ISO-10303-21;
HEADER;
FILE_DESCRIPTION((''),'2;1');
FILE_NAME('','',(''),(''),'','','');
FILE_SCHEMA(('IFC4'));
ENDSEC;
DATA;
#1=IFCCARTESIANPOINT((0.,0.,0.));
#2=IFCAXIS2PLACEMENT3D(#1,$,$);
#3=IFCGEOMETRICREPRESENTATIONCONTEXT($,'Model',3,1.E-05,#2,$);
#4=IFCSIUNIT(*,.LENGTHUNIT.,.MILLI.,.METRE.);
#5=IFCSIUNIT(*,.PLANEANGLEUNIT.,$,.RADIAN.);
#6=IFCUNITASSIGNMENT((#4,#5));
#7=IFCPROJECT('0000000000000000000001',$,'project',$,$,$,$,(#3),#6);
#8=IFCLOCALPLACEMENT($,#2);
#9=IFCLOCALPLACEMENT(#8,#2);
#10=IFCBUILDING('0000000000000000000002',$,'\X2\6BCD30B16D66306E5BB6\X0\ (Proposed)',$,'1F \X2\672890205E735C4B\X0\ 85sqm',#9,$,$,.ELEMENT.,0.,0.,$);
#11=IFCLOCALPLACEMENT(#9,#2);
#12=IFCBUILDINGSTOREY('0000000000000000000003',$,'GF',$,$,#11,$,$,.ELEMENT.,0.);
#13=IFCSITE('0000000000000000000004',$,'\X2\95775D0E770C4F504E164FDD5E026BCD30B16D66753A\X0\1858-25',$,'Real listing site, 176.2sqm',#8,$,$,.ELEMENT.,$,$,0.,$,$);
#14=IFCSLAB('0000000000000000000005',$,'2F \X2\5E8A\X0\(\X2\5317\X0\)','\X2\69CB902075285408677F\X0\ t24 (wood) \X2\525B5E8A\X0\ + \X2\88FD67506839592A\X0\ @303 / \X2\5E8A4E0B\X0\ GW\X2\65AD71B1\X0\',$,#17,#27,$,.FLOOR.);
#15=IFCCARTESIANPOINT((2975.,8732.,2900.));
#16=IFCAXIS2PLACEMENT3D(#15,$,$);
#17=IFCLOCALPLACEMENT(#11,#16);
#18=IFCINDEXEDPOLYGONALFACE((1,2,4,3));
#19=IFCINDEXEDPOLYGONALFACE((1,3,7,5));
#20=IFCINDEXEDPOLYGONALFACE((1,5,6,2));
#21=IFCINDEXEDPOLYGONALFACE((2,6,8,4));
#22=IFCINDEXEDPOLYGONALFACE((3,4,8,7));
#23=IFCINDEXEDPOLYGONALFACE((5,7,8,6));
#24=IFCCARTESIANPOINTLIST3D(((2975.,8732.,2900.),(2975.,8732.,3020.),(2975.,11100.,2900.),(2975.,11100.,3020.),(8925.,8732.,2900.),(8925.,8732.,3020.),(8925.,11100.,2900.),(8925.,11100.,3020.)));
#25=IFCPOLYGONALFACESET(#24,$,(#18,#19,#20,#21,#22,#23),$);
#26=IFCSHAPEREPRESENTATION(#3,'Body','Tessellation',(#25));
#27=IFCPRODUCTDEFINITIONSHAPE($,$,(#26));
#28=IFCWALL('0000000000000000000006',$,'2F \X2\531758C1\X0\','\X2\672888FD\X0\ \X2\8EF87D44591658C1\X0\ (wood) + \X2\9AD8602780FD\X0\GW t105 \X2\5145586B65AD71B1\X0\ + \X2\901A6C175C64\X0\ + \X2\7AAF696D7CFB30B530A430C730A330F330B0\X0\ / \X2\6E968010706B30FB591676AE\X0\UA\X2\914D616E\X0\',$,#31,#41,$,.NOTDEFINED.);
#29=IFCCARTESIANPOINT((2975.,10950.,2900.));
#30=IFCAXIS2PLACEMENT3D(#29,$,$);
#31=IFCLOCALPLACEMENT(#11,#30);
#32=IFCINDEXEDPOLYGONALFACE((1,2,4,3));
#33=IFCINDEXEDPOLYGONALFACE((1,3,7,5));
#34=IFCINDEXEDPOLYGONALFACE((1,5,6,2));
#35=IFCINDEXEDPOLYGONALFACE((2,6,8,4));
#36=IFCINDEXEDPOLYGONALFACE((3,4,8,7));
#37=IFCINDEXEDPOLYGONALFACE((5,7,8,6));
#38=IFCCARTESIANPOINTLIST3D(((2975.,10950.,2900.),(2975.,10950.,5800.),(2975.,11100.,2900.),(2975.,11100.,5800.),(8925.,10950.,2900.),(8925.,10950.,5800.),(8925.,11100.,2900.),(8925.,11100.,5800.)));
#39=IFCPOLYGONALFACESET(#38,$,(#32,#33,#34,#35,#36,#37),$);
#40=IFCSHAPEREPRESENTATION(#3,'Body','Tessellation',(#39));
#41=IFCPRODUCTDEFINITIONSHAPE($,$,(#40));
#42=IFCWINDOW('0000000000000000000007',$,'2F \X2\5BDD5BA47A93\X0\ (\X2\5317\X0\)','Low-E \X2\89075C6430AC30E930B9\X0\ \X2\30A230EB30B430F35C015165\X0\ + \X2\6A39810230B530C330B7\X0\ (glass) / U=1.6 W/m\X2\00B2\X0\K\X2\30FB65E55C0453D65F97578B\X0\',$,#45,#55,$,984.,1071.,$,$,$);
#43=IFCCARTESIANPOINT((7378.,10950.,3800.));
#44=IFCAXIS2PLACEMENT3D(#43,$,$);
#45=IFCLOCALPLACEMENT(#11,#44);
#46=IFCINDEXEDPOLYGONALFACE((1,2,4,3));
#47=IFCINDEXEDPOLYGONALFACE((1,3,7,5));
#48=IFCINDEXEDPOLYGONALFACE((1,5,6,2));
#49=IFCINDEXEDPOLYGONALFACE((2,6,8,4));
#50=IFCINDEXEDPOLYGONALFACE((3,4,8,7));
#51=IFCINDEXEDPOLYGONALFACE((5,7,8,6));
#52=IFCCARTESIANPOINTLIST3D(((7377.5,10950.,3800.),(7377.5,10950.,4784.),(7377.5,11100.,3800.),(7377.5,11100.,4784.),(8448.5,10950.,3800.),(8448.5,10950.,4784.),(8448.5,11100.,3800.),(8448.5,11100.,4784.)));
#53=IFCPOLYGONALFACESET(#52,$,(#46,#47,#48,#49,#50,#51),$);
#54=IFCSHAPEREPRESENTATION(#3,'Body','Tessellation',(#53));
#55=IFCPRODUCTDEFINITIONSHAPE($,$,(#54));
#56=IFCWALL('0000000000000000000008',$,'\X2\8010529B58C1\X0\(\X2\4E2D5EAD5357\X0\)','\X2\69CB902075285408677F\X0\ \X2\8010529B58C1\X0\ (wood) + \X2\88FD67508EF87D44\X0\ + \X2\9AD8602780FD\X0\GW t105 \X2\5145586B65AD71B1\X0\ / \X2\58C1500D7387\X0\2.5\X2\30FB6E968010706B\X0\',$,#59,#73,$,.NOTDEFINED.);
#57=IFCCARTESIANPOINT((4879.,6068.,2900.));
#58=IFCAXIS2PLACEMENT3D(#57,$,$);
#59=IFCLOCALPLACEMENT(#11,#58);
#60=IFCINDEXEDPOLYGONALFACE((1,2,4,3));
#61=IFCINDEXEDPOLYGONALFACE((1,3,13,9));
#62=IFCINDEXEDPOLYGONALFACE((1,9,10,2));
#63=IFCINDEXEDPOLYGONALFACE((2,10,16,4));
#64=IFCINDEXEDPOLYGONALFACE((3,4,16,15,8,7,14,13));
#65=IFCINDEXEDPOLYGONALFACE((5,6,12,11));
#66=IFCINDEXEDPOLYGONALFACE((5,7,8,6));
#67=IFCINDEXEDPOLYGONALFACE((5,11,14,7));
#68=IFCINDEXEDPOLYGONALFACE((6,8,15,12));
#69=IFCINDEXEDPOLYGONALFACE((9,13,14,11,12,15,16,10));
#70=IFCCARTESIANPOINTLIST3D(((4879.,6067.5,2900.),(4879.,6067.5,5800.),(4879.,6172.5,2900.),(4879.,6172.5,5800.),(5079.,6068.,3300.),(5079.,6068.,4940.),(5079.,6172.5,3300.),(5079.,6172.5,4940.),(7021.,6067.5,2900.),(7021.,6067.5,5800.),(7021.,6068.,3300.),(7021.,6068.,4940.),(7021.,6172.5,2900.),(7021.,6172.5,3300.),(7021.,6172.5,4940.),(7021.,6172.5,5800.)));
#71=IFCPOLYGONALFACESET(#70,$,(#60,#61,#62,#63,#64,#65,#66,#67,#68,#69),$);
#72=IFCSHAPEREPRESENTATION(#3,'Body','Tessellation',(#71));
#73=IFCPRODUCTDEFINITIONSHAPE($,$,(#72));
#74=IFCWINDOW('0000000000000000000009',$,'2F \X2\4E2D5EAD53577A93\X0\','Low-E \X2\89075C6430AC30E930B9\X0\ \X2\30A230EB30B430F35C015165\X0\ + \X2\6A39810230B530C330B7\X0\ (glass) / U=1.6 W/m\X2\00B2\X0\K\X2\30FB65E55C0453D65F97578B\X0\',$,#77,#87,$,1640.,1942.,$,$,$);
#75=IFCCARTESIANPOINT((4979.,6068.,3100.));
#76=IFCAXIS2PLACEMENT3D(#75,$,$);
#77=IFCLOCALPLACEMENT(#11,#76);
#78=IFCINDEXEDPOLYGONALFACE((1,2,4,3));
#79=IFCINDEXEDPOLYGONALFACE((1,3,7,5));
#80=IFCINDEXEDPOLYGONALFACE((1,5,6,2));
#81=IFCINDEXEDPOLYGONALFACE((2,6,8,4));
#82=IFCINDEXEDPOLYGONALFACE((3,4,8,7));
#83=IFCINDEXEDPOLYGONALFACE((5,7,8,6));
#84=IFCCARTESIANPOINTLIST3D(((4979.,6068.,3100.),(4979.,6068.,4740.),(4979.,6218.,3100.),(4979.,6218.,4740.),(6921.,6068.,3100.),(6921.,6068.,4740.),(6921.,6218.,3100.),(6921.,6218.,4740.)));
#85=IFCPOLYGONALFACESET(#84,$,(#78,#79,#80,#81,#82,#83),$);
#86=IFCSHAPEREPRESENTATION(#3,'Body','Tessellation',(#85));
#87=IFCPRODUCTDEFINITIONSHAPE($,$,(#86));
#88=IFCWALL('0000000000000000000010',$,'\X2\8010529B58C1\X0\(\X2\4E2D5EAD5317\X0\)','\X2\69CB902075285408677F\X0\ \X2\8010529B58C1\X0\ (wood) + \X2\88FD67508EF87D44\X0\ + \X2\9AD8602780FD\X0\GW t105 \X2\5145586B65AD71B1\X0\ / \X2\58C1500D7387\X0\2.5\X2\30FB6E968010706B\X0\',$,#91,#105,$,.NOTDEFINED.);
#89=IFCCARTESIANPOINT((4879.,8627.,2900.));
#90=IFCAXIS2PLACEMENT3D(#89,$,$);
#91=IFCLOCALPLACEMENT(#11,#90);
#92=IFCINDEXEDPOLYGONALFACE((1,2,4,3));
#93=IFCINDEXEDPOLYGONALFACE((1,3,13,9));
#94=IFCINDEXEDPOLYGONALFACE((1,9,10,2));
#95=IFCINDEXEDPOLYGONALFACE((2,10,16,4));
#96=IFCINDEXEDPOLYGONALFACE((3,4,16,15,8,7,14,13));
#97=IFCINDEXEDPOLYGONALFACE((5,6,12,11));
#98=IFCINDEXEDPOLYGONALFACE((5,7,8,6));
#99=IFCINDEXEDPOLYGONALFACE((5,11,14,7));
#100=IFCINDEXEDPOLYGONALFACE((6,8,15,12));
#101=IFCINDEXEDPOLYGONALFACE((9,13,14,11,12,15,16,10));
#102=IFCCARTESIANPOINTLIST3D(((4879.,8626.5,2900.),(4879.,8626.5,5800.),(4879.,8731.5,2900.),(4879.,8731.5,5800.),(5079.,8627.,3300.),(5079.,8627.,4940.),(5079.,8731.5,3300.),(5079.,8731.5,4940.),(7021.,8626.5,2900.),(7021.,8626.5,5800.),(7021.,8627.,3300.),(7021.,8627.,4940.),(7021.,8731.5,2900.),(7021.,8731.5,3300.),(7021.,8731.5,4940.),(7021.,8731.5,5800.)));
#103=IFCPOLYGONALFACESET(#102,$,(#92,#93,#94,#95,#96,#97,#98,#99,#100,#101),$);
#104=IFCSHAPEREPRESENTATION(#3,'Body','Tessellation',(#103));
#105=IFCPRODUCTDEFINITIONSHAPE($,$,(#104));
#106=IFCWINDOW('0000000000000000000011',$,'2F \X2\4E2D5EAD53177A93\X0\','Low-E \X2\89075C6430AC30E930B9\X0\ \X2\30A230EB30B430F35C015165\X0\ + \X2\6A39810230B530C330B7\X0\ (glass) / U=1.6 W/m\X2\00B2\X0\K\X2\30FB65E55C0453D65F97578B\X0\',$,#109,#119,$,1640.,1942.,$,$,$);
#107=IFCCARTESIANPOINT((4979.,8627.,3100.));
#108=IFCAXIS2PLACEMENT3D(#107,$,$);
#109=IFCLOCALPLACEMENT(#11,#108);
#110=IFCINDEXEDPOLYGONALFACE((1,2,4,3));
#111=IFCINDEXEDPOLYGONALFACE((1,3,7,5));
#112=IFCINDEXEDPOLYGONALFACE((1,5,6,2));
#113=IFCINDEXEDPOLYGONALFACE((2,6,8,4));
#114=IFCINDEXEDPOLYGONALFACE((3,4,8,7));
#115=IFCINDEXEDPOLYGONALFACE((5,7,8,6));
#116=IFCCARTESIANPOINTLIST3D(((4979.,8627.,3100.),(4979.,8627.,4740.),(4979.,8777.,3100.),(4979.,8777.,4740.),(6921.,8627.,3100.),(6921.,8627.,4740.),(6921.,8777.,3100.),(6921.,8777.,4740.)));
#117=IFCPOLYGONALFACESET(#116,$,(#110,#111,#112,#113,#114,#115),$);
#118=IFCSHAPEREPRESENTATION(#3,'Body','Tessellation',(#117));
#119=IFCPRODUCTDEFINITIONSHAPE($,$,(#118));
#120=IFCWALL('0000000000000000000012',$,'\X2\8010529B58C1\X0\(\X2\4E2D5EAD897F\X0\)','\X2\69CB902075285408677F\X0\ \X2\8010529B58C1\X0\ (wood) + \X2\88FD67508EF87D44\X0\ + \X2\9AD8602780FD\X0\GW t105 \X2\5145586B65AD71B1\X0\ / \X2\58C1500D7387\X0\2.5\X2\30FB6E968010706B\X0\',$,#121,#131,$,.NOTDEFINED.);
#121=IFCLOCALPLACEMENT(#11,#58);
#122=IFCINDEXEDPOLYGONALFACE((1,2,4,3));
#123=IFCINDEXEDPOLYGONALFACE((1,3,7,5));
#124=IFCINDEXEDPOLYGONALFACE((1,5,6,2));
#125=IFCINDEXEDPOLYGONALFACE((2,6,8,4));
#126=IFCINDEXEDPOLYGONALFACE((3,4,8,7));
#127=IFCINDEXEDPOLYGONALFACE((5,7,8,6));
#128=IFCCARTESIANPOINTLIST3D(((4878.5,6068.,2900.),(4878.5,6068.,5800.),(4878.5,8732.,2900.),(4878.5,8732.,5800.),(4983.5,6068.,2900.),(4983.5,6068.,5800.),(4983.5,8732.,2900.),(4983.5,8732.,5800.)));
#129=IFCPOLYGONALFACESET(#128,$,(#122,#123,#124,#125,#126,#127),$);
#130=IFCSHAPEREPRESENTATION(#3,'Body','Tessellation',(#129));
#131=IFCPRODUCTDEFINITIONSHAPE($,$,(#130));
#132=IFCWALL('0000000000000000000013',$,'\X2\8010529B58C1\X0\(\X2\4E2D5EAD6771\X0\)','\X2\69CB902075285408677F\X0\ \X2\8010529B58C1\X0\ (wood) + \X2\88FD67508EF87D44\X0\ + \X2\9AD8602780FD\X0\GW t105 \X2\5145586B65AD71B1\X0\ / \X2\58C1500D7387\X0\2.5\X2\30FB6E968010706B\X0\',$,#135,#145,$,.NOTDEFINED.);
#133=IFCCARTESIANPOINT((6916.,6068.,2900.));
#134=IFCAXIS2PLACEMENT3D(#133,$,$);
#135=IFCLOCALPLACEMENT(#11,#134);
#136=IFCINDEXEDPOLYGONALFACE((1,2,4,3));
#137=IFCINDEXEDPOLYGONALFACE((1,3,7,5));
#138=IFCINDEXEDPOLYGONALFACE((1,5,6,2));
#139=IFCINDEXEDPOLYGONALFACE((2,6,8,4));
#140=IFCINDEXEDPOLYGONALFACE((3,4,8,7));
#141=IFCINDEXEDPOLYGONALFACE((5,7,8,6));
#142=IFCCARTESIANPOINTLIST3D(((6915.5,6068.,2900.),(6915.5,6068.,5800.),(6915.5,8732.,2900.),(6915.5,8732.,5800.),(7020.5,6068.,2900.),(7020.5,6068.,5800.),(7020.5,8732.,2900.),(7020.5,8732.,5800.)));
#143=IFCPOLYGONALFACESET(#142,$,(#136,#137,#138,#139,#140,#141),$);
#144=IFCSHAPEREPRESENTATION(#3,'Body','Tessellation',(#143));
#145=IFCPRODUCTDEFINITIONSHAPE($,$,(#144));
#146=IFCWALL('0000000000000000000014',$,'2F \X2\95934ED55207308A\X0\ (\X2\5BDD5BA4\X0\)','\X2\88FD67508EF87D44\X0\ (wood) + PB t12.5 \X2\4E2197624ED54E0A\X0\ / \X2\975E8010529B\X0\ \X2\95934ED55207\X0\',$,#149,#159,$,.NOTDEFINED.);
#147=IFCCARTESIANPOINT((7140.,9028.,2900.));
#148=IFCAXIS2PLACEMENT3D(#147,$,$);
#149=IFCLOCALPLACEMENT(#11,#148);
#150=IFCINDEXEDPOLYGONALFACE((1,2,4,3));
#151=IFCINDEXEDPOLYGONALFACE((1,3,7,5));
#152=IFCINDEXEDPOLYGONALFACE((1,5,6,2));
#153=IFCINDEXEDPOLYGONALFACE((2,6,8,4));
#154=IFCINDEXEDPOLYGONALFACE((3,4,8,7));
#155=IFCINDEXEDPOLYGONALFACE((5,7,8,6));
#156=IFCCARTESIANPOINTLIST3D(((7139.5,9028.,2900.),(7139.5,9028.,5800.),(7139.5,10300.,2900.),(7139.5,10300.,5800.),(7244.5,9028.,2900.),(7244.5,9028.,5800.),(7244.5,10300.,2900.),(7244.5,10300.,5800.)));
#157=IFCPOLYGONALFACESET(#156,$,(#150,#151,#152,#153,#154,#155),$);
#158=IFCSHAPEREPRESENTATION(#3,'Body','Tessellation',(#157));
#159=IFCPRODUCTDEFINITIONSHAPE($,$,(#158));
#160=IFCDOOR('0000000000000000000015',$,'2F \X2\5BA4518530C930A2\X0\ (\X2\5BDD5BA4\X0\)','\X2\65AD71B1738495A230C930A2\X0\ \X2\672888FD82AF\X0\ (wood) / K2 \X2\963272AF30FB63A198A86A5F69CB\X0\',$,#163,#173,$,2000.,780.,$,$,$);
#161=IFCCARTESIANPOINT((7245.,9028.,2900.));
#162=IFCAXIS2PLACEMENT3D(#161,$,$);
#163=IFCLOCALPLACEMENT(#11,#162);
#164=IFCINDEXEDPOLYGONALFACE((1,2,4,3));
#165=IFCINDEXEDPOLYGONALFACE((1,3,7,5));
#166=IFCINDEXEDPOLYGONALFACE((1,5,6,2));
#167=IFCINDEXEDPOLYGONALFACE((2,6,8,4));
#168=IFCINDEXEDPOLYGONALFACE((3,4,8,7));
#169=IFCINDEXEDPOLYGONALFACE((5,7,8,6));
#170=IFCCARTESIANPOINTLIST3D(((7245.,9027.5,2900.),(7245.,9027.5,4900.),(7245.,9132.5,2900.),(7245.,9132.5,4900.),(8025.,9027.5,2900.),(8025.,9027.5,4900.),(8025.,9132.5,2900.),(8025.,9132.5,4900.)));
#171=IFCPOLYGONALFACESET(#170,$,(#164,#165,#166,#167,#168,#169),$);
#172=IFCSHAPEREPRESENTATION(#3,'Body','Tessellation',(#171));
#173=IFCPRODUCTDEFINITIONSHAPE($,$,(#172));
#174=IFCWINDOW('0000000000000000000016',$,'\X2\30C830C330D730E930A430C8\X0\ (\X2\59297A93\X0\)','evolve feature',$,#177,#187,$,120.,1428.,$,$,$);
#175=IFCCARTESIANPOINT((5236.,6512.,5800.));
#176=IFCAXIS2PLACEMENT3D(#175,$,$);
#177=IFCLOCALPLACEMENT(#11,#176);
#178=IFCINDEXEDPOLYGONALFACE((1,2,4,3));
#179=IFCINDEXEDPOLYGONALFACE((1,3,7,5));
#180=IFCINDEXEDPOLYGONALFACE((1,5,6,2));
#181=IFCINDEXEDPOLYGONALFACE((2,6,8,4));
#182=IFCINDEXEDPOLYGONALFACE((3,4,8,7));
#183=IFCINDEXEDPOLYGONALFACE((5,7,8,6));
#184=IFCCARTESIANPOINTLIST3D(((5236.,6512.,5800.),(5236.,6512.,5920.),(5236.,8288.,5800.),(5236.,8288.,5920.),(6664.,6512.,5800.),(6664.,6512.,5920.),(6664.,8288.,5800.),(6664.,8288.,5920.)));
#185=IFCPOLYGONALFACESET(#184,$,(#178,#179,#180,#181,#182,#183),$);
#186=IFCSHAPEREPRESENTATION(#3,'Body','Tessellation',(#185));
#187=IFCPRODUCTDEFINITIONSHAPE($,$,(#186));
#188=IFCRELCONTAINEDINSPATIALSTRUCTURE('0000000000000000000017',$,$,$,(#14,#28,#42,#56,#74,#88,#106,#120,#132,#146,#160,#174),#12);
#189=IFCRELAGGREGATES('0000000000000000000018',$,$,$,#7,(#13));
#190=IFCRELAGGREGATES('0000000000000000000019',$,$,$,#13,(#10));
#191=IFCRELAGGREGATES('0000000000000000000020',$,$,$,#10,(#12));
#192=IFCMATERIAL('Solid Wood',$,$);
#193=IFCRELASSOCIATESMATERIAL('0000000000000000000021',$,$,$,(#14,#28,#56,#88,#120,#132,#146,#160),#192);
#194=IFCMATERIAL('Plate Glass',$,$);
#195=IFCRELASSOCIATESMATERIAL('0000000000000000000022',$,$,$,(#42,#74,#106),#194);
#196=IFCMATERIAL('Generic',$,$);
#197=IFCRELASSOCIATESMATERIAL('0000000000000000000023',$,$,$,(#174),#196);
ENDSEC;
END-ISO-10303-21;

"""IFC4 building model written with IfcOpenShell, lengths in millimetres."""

from ifc_helpers import new_model, si_unit, frame, frame_2d, origin, place, context, project, spatial, rectangle, extrude, material, element, fill, save


model = new_model("IFC4")

# Units and contexts
model_context = context("Model", 3, precision=1e-05, world=origin())
ifc_project = project(units=[si_unit("LENGTHUNIT", "METRE", prefix="MILLI"), si_unit("PLANEANGLEUNIT", "RADIAN")], contexts=[model_context])

# Site, building, storey
site_placement = place(None, origin())
site = spatial("IfcSite", under=ifc_project, at=site_placement, Name="長崎県佐世保市母ケ浦町1858-25", ObjectType="Real listing site, 176.2sqm", CompositionType="ELEMENT", RefElevation=0.0)
building_placement = place(site_placement, origin())
building = spatial("IfcBuilding", under=site, at=building_placement, Name="母ケ浦の家 (Proposed)", ObjectType="1F 木造平屋 85sqm", CompositionType="ELEMENT", ElevationOfRefHeight=0.0, ElevationOfTerrain=0.0)
storey_placement = place(building_placement, origin())
storey = spatial("IfcBuildingStorey", under=building, at=storey_placement, Name="GF", CompositionType="ELEMENT", Elevation=0.0)

# Slab
ifc_material_1 = material(Name="Solid Wood")
slab_placement = place(storey_placement, frame((2975.0, 8732.0, 2900.0)))
element("IfcSlab", 1, at=slab_placement, inside=storey, material=ifc_material_1, Name="2F 床(北)", Description="構造用合板 t24 (wood) 剛床 + 製材根太 @303 / 床下 GW断熱", PredefinedType="FLOOR", context=model_context, shape_type="SweptSolid", body=[
    extrude(rectangle(XDim=5950.0, YDim=2368.0, at=frame_2d((2975.0, 1184.0))), frame((2975.0, 8732.0, 2900.0)), (0.0, 0.0, 1.0), 120.0),
])

# Walls, openings, windows
wall_1_placement = place(storey_placement, frame((2975.0, 10950.0, 2900.0)))
wall_1 = element("IfcWall", 2, at=wall_1_placement, inside=storey, material=ifc_material_1, Name="2F 北壁", Description="木製 軸組外壁 (wood) + 高性能GW t105 充填断熱 + 通気層 + 窯業系サイディング / 準耐火・外皮UA配慮", PredefinedType="NOTDEFINED", context=model_context, shape_type="SweptSolid", body=[
    extrude(rectangle(XDim=5950.0, YDim=150.0, at=frame_2d((2975.0, 75.0))), frame((2975.0, 10950.0, 2900.0)), (0.0, 0.0, 1.0), 2900.0),
])
opening_1_placement = place(storey_placement, frame((7378.0, 10950.0, 3800.0)))
opening_1 = element("IfcOpeningElement", 3, at=opening_1_placement, cuts=wall_1, PredefinedType="NOTDEFINED", context=model_context, shape_type="SweptSolid", body=[
    extrude(rectangle(XDim=1071.0, YDim=150.0, at=frame_2d((535.0, 75.0))), frame((7378.0, 10950.0, 3800.0)), (0.0, 0.0, 1.0), 984.0),
])
ifc_material_2 = material(Name="Plate Glass")
window_1_placement = place(storey_placement, frame((7378.0, 10950.0, 3800.0)))
window_1 = element("IfcWindow", 4, at=window_1_placement, inside=storey, material=ifc_material_2, Name="2F 寝室窓 (北)", Description="Low-E 複層ガラス アルゴン封入 + 樹脂サッシ (glass) / U=1.6 W/m²K・日射取得型", OverallHeight=984.0, OverallWidth=1071.0, context=model_context, shape_type="SweptSolid", body=[
    extrude(rectangle(XDim=1071.0, YDim=150.0, at=frame_2d((535.0, 75.0))), frame((7378.0, 10950.0, 3800.0)), (0.0, 0.0, 1.0), 984.0),
])
fill(opening_1, window_1)
wall_2_placement = place(storey_placement, frame((4879.0, 6068.0, 2900.0)))
wall_2 = element("IfcWall", 5, at=wall_2_placement, inside=storey, material=ifc_material_1, Name="耐力壁(中庭南)", Description="構造用合板 耐力壁 (wood) + 製材軸組 + 高性能GW t105 充填断熱 / 壁倍率2.5・準耐火", PredefinedType="NOTDEFINED", context=model_context, shape_type="SweptSolid", body=[
    extrude(rectangle(XDim=2142.0, YDim=105.0, at=frame_2d((1071.0, 52.0))), frame((4879.0, 6068.0, 2900.0)), (0.0, 0.0, 1.0), 2900.0),
])
opening_2_placement = place(storey_placement, frame((4979.0, 6068.0, 3100.0)))
opening_2 = element("IfcOpeningElement", 6, at=opening_2_placement, cuts=wall_2, PredefinedType="NOTDEFINED", context=model_context, shape_type="SweptSolid", body=[
    extrude(rectangle(XDim=1942.0, YDim=150.0, at=frame_2d((971.0, 75.0))), frame((4979.0, 6068.0, 3100.0)), (0.0, 0.0, 1.0), 1640.0),
])
window_2_placement = place(storey_placement, frame((4979.0, 6068.0, 3100.0)))
window_2 = element("IfcWindow", 7, at=window_2_placement, inside=storey, material=ifc_material_2, Name="2F 中庭南窓", Description="Low-E 複層ガラス アルゴン封入 + 樹脂サッシ (glass) / U=1.6 W/m²K・日射取得型", OverallHeight=1640.0, OverallWidth=1942.0, context=model_context, shape_type="SweptSolid", body=[
    extrude(rectangle(XDim=1942.0, YDim=150.0, at=frame_2d((971.0, 75.0))), frame((4979.0, 6068.0, 3100.0)), (0.0, 0.0, 1.0), 1640.0),
])
fill(opening_2, window_2)
wall_3_placement = place(storey_placement, frame((4879.0, 8627.0, 2900.0)))
wall_3 = element("IfcWall", 8, at=wall_3_placement, inside=storey, material=ifc_material_1, Name="耐力壁(中庭北)", Description="構造用合板 耐力壁 (wood) + 製材軸組 + 高性能GW t105 充填断熱 / 壁倍率2.5・準耐火", PredefinedType="NOTDEFINED", context=model_context, shape_type="SweptSolid", body=[
    extrude(rectangle(XDim=2142.0, YDim=105.0, at=frame_2d((1071.0, 52.0))), frame((4879.0, 8627.0, 2900.0)), (0.0, 0.0, 1.0), 2900.0),
])
opening_3_placement = place(storey_placement, frame((4979.0, 8627.0, 3100.0)))
opening_3 = element("IfcOpeningElement", 9, at=opening_3_placement, cuts=wall_3, PredefinedType="NOTDEFINED", context=model_context, shape_type="SweptSolid", body=[
    extrude(rectangle(XDim=1942.0, YDim=150.0, at=frame_2d((971.0, 75.0))), frame((4979.0, 8627.0, 3100.0)), (0.0, 0.0, 1.0), 1640.0),
])
window_3_placement = place(storey_placement, frame((4979.0, 8627.0, 3100.0)))
window_3 = element("IfcWindow", 10, at=window_3_placement, inside=storey, material=ifc_material_2, Name="2F 中庭北窓", Description="Low-E 複層ガラス アルゴン封入 + 樹脂サッシ (glass) / U=1.6 W/m²K・日射取得型", OverallHeight=1640.0, OverallWidth=1942.0, context=model_context, shape_type="SweptSolid", body=[
    extrude(rectangle(XDim=1942.0, YDim=150.0, at=frame_2d((971.0, 75.0))), frame((4979.0, 8627.0, 3100.0)), (0.0, 0.0, 1.0), 1640.0),
])
fill(opening_3, window_3)

# Walls
wall_4_placement = place(storey_placement, frame((4879.0, 6068.0, 2900.0)))
element("IfcWall", 11, at=wall_4_placement, inside=storey, material=ifc_material_1, Name="耐力壁(中庭西)", Description="構造用合板 耐力壁 (wood) + 製材軸組 + 高性能GW t105 充填断熱 / 壁倍率2.5・準耐火", PredefinedType="NOTDEFINED", context=model_context, shape_type="SweptSolid", body=[
    extrude(rectangle(XDim=105.0, YDim=2664.0, at=frame_2d((52.0, 1332.0))), frame((4879.0, 6068.0, 2900.0)), (0.0, 0.0, 1.0), 2900.0),
])
wall_5_placement = place(storey_placement, frame((6916.0, 6068.0, 2900.0)))
element("IfcWall", 12, at=wall_5_placement, inside=storey, material=ifc_material_1, Name="耐力壁(中庭東)", Description="構造用合板 耐力壁 (wood) + 製材軸組 + 高性能GW t105 充填断熱 / 壁倍率2.5・準耐火", PredefinedType="NOTDEFINED", context=model_context, shape_type="SweptSolid", body=[
    extrude(rectangle(XDim=105.0, YDim=2664.0, at=frame_2d((52.0, 1332.0))), frame((6916.0, 6068.0, 2900.0)), (0.0, 0.0, 1.0), 2900.0),
])
wall_6_placement = place(storey_placement, frame((7140.0, 9028.0, 2900.0)))
element("IfcWall", 13, at=wall_6_placement, inside=storey, material=ifc_material_1, Name="2F 間仕切り (寝室)", Description="製材軸組 (wood) + PB t12.5 両面仕上 / 非耐力 間仕切", PredefinedType="NOTDEFINED", context=model_context, shape_type="SweptSolid", body=[
    extrude(rectangle(XDim=105.0, YDim=1272.0, at=frame_2d((52.0, 636.0))), frame((7140.0, 9028.0, 2900.0)), (0.0, 0.0, 1.0), 2900.0),
])

# Door
door_placement = place(storey_placement, frame((7245.0, 9028.0, 2900.0)))
element("IfcDoor", 14, at=door_placement, inside=storey, material=ifc_material_1, Name="2F 室内ドア (寝室)", Description="断熱玄関ドア 木製芯 (wood) / K2 防犯・採風機構", OverallHeight=2000.0, OverallWidth=780.0, context=model_context, shape_type="SweptSolid", body=[
    extrude(rectangle(XDim=780.0, YDim=105.0, at=frame_2d((390.0, 52.0))), frame((7245.0, 9028.0, 2900.0)), (0.0, 0.0, 1.0), 2000.0),
])

# Window
ifc_material_3 = material(Name="Generic")
window_4_placement = place(storey_placement, frame((5236.0, 6512.0, 5800.0)))
element("IfcWindow", 15, at=window_4_placement, inside=storey, material=ifc_material_3, Name="トップライト (天窓)", Description="evolve feature", OverallHeight=120.0, OverallWidth=1428.0, context=model_context, shape_type="SweptSolid", body=[
    extrude(rectangle(XDim=1428.0, YDim=1776.0, at=frame_2d((714.0, 888.0))), frame((5236.0, 6512.0, 5800.0)), (0.0, 0.0, 1.0), 120.0),
])

save(model, "model.ifc")
